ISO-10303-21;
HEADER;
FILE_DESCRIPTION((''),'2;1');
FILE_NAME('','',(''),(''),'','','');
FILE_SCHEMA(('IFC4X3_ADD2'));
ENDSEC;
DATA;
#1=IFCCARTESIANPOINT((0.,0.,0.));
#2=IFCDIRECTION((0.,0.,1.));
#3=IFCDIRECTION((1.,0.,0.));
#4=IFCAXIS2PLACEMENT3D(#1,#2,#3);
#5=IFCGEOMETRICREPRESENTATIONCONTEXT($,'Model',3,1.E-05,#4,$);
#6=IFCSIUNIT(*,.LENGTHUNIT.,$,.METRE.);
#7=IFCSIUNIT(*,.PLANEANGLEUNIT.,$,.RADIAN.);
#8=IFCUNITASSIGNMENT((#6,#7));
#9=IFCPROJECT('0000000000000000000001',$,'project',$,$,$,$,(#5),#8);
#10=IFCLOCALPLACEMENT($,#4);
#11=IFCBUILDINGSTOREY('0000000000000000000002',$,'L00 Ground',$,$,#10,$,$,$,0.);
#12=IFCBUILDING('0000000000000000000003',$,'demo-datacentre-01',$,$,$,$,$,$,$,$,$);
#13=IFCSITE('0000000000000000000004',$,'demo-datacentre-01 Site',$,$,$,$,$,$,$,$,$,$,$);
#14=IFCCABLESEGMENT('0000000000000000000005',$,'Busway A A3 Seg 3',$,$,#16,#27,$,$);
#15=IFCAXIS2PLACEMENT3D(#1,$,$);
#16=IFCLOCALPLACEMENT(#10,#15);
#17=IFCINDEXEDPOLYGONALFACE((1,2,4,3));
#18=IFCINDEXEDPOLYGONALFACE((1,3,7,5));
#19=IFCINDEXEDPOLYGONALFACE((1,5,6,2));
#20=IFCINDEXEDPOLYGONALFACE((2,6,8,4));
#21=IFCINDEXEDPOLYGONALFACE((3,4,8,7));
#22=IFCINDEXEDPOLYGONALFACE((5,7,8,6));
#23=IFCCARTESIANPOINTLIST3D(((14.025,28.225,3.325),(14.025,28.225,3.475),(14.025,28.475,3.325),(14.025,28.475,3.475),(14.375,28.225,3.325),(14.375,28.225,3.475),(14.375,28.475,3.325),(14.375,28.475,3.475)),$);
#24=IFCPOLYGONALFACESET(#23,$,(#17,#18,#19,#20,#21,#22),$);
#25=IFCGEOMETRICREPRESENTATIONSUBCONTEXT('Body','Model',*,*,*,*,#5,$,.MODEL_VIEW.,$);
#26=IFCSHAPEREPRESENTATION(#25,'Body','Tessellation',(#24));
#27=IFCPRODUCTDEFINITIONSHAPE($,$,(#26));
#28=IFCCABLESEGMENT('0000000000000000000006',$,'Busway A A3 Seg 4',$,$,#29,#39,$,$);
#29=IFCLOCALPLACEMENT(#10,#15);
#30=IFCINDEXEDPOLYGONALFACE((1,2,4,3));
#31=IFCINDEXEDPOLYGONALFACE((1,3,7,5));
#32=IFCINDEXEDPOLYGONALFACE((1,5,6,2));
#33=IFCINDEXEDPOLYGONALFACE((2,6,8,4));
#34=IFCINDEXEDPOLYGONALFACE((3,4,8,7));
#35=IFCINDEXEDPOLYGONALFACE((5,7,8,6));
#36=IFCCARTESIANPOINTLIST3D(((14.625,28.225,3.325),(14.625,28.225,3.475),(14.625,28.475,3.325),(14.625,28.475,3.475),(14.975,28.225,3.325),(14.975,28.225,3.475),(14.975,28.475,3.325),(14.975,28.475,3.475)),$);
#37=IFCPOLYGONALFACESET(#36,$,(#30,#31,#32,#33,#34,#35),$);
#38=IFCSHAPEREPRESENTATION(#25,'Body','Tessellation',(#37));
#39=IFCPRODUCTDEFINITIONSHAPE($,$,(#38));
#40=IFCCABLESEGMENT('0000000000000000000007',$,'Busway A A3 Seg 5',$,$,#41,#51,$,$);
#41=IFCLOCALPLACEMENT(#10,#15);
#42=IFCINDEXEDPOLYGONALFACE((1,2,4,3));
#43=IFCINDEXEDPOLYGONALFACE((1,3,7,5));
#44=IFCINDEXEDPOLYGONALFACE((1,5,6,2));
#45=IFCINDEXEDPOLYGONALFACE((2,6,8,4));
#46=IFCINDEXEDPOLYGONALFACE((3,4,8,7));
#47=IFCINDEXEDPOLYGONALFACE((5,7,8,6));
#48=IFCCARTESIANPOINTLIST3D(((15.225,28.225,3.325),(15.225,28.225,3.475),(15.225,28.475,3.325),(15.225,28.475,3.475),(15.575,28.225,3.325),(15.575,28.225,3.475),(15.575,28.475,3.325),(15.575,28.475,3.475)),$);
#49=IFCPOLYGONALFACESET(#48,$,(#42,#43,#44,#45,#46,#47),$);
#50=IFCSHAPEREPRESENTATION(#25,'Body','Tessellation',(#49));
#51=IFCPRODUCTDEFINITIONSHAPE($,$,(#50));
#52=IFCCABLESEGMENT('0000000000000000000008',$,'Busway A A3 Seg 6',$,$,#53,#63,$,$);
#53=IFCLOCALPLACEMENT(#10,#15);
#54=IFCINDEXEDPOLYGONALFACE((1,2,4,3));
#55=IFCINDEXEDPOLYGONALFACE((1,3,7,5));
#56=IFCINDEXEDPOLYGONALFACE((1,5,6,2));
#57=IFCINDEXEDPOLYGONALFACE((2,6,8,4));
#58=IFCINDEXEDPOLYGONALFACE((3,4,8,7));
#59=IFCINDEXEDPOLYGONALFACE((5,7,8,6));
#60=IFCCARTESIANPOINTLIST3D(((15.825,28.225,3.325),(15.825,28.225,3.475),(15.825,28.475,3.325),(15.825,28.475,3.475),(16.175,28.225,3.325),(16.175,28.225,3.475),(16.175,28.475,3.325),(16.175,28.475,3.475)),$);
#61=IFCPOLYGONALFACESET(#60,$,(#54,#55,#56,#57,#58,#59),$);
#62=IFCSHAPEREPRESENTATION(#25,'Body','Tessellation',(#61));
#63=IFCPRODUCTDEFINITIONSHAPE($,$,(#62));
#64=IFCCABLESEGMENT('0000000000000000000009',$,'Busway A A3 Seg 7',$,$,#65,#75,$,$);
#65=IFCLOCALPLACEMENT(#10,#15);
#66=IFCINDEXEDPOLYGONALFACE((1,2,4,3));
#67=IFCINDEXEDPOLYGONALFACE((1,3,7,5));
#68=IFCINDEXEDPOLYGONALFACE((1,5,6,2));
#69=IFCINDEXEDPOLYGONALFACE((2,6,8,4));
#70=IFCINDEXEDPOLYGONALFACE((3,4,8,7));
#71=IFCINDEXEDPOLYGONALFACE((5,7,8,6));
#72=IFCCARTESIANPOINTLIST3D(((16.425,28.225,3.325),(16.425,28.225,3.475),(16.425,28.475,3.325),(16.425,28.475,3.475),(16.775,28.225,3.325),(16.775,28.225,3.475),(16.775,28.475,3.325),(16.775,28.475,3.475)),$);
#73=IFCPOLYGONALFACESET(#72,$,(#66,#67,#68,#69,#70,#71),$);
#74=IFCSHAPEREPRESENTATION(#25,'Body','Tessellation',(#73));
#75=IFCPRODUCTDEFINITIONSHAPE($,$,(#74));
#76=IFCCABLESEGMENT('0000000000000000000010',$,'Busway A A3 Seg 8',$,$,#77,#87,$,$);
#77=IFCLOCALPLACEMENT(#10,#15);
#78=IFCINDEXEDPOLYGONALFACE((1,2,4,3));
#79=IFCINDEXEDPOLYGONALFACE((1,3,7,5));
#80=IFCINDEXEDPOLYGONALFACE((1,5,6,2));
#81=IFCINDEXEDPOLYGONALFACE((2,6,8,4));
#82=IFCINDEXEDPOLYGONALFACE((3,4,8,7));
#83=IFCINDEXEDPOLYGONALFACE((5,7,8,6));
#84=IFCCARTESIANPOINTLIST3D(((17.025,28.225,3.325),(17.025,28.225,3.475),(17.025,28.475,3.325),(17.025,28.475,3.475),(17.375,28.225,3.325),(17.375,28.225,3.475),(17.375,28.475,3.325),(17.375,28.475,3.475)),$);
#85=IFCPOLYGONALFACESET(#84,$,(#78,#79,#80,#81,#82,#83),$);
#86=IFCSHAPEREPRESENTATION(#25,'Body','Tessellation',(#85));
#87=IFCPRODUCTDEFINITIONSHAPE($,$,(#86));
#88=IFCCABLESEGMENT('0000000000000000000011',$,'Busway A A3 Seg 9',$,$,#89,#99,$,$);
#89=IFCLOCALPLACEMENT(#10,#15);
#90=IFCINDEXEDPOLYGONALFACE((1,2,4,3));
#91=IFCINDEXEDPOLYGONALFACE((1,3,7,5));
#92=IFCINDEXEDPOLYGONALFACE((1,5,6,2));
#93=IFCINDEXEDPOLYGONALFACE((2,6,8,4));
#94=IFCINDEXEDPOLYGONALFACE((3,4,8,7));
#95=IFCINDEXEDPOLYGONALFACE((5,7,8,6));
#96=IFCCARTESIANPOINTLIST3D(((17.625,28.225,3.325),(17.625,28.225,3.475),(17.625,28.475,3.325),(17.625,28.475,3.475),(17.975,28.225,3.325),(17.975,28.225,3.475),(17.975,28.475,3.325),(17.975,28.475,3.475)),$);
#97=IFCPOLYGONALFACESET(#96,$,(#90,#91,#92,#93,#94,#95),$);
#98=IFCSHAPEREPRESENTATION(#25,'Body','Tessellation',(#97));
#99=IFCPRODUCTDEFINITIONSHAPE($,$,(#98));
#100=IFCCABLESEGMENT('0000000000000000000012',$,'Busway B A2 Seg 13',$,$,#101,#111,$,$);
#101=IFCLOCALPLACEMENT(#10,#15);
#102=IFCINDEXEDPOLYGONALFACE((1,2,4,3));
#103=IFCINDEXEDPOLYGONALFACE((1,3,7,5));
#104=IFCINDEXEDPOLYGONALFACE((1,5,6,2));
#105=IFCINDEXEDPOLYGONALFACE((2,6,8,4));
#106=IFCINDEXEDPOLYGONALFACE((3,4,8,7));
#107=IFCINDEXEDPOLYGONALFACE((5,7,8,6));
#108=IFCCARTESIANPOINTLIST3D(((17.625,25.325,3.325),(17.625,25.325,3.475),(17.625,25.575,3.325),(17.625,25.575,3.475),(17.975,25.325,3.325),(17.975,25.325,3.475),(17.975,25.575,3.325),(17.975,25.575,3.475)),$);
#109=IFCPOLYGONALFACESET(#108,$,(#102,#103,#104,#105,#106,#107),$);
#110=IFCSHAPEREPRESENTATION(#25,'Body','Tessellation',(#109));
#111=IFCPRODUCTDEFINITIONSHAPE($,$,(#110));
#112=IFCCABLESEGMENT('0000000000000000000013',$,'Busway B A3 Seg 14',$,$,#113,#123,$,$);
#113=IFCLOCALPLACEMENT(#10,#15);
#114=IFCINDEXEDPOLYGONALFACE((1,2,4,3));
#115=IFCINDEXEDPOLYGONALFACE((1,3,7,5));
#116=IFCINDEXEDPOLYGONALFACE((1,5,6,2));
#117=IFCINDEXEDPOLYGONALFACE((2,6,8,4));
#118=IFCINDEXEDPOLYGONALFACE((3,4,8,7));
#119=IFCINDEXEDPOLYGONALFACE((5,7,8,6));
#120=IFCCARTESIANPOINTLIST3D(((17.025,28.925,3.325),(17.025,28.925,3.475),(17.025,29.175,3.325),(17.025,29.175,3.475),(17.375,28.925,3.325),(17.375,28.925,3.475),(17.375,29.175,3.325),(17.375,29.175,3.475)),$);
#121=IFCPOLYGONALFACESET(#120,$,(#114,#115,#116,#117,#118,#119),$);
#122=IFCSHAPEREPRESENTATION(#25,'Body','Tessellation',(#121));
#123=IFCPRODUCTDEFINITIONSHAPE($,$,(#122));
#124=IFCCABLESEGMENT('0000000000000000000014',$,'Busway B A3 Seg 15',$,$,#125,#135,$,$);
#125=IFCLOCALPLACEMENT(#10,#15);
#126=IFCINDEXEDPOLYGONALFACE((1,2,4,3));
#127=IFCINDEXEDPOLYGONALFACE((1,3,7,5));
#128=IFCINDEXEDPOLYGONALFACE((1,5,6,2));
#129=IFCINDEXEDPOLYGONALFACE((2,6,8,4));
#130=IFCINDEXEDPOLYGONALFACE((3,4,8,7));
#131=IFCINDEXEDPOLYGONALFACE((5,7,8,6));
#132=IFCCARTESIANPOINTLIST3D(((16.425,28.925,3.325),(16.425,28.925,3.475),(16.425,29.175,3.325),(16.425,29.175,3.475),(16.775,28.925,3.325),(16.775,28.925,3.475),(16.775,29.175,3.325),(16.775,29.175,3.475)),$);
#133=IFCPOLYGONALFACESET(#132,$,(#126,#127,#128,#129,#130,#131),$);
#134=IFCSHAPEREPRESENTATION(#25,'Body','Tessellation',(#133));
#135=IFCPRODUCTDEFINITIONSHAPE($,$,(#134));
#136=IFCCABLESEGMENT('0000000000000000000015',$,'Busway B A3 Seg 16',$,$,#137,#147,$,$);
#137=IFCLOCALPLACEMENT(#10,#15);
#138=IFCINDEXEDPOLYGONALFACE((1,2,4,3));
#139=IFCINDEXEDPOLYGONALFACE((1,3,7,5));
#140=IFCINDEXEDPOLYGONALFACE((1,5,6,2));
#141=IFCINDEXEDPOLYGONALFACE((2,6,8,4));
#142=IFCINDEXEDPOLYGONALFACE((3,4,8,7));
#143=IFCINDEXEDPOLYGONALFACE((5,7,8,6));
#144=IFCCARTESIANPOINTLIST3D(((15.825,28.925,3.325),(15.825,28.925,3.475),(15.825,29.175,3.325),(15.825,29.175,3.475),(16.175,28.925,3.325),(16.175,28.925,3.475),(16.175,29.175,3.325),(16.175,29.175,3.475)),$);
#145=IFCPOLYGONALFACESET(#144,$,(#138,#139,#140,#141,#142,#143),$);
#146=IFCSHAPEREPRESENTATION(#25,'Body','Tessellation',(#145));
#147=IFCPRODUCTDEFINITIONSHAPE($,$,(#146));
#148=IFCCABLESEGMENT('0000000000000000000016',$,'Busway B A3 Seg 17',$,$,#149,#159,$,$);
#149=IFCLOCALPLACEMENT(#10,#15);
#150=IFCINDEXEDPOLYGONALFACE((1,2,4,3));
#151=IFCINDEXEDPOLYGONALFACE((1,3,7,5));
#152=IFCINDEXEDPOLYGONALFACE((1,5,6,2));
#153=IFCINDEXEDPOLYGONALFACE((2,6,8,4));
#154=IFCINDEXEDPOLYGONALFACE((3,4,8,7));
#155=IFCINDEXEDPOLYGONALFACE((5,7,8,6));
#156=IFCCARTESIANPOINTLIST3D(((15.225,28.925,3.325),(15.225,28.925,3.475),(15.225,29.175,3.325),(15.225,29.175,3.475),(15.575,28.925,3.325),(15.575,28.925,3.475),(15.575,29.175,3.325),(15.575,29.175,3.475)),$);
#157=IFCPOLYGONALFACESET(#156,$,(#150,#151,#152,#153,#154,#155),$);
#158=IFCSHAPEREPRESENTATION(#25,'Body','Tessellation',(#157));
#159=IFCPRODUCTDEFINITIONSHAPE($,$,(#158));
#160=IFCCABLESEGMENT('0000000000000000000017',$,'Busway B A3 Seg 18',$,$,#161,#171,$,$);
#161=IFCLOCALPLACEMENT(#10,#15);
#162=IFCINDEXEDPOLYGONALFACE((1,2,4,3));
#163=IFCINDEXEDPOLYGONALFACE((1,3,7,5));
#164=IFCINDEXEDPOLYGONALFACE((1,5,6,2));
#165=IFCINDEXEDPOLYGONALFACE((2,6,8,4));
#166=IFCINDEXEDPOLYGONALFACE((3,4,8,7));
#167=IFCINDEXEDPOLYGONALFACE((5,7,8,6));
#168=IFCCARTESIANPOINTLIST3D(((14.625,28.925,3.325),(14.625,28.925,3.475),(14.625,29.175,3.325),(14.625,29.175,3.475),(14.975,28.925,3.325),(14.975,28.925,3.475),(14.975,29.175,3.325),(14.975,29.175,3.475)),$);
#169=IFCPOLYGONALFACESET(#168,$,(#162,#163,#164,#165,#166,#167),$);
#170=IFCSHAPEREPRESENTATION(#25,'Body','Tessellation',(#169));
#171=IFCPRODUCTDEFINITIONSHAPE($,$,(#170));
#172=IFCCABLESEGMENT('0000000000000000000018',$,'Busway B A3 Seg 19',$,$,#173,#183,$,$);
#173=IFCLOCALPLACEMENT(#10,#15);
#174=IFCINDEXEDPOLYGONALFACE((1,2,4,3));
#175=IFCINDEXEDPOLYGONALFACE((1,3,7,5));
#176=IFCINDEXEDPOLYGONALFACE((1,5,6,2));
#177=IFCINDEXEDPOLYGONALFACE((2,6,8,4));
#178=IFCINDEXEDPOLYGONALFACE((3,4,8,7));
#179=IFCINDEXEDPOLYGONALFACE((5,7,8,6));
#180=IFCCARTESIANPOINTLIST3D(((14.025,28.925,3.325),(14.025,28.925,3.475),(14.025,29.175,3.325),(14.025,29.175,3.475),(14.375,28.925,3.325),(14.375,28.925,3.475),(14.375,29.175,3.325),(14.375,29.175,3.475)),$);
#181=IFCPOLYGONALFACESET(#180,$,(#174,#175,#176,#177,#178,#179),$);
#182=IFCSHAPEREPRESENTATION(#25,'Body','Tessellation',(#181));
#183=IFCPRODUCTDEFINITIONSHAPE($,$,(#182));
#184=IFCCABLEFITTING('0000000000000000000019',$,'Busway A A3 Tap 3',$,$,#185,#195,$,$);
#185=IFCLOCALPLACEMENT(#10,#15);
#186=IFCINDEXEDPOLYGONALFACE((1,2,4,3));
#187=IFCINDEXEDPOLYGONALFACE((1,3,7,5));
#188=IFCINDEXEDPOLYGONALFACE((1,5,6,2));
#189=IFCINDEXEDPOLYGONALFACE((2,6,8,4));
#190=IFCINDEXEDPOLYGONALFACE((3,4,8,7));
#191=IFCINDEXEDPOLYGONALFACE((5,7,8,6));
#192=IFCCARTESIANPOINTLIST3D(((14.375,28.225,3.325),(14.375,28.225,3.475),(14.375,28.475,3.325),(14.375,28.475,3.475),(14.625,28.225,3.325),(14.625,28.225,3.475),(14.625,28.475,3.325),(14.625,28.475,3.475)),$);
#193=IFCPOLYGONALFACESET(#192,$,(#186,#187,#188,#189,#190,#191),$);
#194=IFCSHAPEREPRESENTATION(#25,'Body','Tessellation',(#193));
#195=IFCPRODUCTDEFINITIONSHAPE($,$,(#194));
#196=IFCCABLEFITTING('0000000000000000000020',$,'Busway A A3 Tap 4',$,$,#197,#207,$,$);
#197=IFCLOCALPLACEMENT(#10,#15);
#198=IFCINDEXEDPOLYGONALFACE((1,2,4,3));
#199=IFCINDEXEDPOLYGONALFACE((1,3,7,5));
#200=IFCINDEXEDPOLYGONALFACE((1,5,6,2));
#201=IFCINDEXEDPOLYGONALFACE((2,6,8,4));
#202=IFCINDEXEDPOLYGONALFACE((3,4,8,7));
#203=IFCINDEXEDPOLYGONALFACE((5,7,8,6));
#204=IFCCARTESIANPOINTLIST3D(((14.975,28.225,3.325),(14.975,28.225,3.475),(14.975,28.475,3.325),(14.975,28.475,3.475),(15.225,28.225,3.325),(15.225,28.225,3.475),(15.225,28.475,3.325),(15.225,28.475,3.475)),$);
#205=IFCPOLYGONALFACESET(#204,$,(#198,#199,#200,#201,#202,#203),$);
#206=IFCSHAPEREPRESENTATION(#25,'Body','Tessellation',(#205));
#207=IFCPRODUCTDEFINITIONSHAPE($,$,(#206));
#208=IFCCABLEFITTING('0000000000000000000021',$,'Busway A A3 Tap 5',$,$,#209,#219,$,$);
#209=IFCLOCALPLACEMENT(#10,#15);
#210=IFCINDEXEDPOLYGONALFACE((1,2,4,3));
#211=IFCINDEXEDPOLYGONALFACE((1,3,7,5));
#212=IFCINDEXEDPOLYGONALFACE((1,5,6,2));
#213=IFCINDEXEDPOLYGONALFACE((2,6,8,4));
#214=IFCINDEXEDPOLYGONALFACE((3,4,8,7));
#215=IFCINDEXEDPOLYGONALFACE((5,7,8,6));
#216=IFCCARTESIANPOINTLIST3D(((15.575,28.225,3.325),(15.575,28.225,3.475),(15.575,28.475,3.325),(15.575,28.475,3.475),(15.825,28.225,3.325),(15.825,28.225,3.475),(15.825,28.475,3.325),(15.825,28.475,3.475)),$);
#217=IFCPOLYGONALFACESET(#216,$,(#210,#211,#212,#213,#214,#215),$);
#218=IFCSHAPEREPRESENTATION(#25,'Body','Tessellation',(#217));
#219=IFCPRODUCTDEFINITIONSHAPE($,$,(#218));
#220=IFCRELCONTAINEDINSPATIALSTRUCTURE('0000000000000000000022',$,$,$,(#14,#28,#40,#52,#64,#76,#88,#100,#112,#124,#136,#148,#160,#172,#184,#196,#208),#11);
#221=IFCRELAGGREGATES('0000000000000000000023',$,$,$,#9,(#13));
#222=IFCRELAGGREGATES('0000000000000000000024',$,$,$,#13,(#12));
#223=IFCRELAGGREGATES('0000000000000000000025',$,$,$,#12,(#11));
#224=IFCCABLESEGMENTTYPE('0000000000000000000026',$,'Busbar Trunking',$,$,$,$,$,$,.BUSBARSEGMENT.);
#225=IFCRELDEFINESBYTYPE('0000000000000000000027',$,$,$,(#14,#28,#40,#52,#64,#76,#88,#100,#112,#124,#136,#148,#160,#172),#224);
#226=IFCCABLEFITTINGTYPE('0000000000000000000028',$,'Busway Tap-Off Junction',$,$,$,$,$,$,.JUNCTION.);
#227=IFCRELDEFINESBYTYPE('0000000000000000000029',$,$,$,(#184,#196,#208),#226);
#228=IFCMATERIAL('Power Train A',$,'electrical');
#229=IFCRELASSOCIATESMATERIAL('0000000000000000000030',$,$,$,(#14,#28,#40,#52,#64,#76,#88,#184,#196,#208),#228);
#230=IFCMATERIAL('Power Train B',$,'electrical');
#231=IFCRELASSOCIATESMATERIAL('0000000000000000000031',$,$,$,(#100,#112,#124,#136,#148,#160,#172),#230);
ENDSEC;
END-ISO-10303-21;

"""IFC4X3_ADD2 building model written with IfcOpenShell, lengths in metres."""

from ifc_helpers import new_model, si_unit, frame, origin_with_axes, place, context, subcontext, project, spatial, rectangle, extrude, material, type_object, element, save


model = new_model("IFC4X3_ADD2")

# Units and contexts
model_context = context("Model", 3, precision=1e-05, world=origin_with_axes())
body_context = subcontext(model_context, "Body", "Model", "MODEL_VIEW")
ifc_project = project(units=[si_unit("LENGTHUNIT", "METRE"), si_unit("PLANEANGLEUNIT", "RADIAN")], contexts=[model_context])

# Site, building, storey
site = spatial("IfcSite", under=ifc_project, Name="demo-datacentre-01 Site")
building = spatial("IfcBuilding", under=site, Name="demo-datacentre-01")
storey_placement = place(None, origin_with_axes())
storey = spatial("IfcBuildingStorey", under=building, at=storey_placement, Name="L00 Ground", Elevation=0.0)

# Cable segments
ifc_material_1 = material(Name="Power Train A", Category="electrical")
cable_segment_type_1 = type_object("IfcCableSegmentType", Name="Busbar Trunking", PredefinedType="BUSBARSEGMENT")
cable_segment_1_placement = place(storey_placement, frame((14.025, 28.35, 3.4), z_axis=(1.0, 0.0, 0.0), x_axis=(0.0, 1.0, 0.0)))
element("IfcCableSegment", 1, at=cable_segment_1_placement, inside=storey, type_object=cable_segment_type_1, material=ifc_material_1, Name="Busway A A3 Seg 3", context=body_context, shape_type="SweptSolid", body=[
    extrude(rectangle(XDim=0.25, YDim=0.15), origin_with_axes(), (0.0, 0.0, 1.0), 0.35),
])
cable_segment_2_placement = place(storey_placement, frame((14.625, 28.35, 3.4), z_axis=(1.0, 0.0, 0.0), x_axis=(0.0, 1.0, 0.0)))
element("IfcCableSegment", 2, at=cable_segment_2_placement, inside=storey, type_object=cable_segment_type_1, material=ifc_material_1, Name="Busway A A3 Seg 4", context=body_context, shape_type="SweptSolid", body=[
    extrude(rectangle(XDim=0.25, YDim=0.15), origin_with_axes(), (0.0, 0.0, 1.0), 0.35),
])
for number, where, z_axis, x_axis, name in (
    (3, (15.225, 28.35, 3.4), (1.0, 0.0, 0.0), (0.0, 1.0, 0.0), "Busway A A3 Seg 5"),
    (4, (15.825, 28.35, 3.4), (1.0, 0.0, 0.0), (0.0, 1.0, 0.0), "Busway A A3 Seg 6"),
):
    element("IfcCableSegment", number, at=place(storey_placement, frame(where, z_axis=z_axis, x_axis=x_axis)), inside=storey, type_object=cable_segment_type_1, material=ifc_material_1, Name=name, context=body_context, shape_type="SweptSolid", body=[
        extrude(rectangle(XDim=0.25, YDim=0.15), origin_with_axes(), (0.0, 0.0, 1.0), 0.35),
    ])
cable_segment_3_placement = place(storey_placement, frame((16.425, 28.35, 3.4), z_axis=(1.0, 0.0, 0.0), x_axis=(0.0, 1.0, 0.0)))
element("IfcCableSegment", 5, at=cable_segment_3_placement, inside=storey, type_object=cable_segment_type_1, material=ifc_material_1, Name="Busway A A3 Seg 7", context=body_context, shape_type="SweptSolid", body=[
    extrude(rectangle(XDim=0.25, YDim=0.15), origin_with_axes(), (0.0, 0.0, 1.0), 0.35),
])
for number, where, z_axis, x_axis, name in (
    (6, (17.025, 28.35, 3.4), (1.0, 0.0, 0.0), (0.0, 1.0, 0.0), "Busway A A3 Seg 8"),
    (7, (17.625, 28.35, 3.4), (1.0, 0.0, 0.0), (0.0, 1.0, 0.0), "Busway A A3 Seg 9"),
):
    element("IfcCableSegment", number, at=place(storey_placement, frame(where, z_axis=z_axis, x_axis=x_axis)), inside=storey, type_object=cable_segment_type_1, material=ifc_material_1, Name=name, context=body_context, shape_type="SweptSolid", body=[
        extrude(rectangle(XDim=0.25, YDim=0.15), origin_with_axes(), (0.0, 0.0, 1.0), 0.35),
    ])
ifc_material_2 = material(Name="Power Train B", Category="electrical")
for number, where, z_axis, x_axis, name in (
    (8, (17.975, 25.45, 3.4), (-1.0, 0.0, 0.0), (0.0, -1.0, 0.0), "Busway B A2 Seg 13"),
    (9, (17.375, 29.05, 3.4), (-1.0, 0.0, 0.0), (0.0, -1.0, 0.0), "Busway B A3 Seg 14"),
):
    element("IfcCableSegment", number, at=place(storey_placement, frame(where, z_axis=z_axis, x_axis=x_axis)), inside=storey, type_object=cable_segment_type_1, material=ifc_material_2, Name=name, context=body_context, shape_type="SweptSolid", body=[
        extrude(rectangle(XDim=0.25, YDim=0.15), origin_with_axes(), (0.0, 0.0, 1.0), 0.35),
    ])
cable_segment_4_placement = place(storey_placement, frame((16.775, 29.05, 3.4), z_axis=(-1.0, 0.0, 0.0), x_axis=(0.0, -1.0, 0.0)))
element("IfcCableSegment", 10, at=cable_segment_4_placement, inside=storey, type_object=cable_segment_type_1, material=ifc_material_2, Name="Busway B A3 Seg 15", context=body_context, shape_type="SweptSolid", body=[
    extrude(rectangle(XDim=0.25, YDim=0.15), origin_with_axes(), (0.0, 0.0, 1.0), 0.35),
])
for number, where, z_axis, x_axis, name in (
    (11, (16.175, 29.05, 3.4), (-1.0, 0.0, 0.0), (0.0, -1.0, 0.0), "Busway B A3 Seg 16"),
    (12, (15.575, 29.05, 3.4), (-1.0, 0.0, 0.0), (0.0, -1.0, 0.0), "Busway B A3 Seg 17"),
):
    element("IfcCableSegment", number, at=place(storey_placement, frame(where, z_axis=z_axis, x_axis=x_axis)), inside=storey, type_object=cable_segment_type_1, material=ifc_material_2, Name=name, context=body_context, shape_type="SweptSolid", body=[
        extrude(rectangle(XDim=0.25, YDim=0.15), origin_with_axes(), (0.0, 0.0, 1.0), 0.35),
    ])
cable_segment_5_placement = place(storey_placement, frame((14.975, 29.05, 3.4), z_axis=(-1.0, 0.0, 0.0), x_axis=(0.0, -1.0, 0.0)))
element("IfcCableSegment", 13, at=cable_segment_5_placement, inside=storey, type_object=cable_segment_type_1, material=ifc_material_2, Name="Busway B A3 Seg 18", context=body_context, shape_type="SweptSolid", body=[
    extrude(rectangle(XDim=0.25, YDim=0.15), origin_with_axes(), (0.0, 0.0, 1.0), 0.35),
])
cable_segment_6_placement = place(storey_placement, frame((14.375, 29.05, 3.4), z_axis=(-1.0, 0.0, 0.0), x_axis=(0.0, -1.0, 0.0)))
element("IfcCableSegment", 14, at=cable_segment_6_placement, inside=storey, type_object=cable_segment_type_1, material=ifc_material_2, Name="Busway B A3 Seg 19", context=body_context, shape_type="SweptSolid", body=[
    extrude(rectangle(XDim=0.25, YDim=0.15), origin_with_axes(), (0.0, 0.0, 1.0), 0.35),
])

# Cable fittings
cable_fitting_type = type_object("IfcCableFittingType", Name="Busway Tap-Off Junction", PredefinedType="JUNCTION")
for number, where, z_axis, x_axis, name in (
    (15, (14.5, 28.35, 3.325), (0.0, 0.0, 1.0), (1.0, 0.0, 0.0), "Busway A A3 Tap 3"),
    (16, (15.1, 28.35, 3.325), (0.0, 0.0, 1.0), (1.0, 0.0, 0.0), "Busway A A3 Tap 4"),
    (17, (15.7, 28.35, 3.325), (0.0, 0.0, 1.0), (1.0, 0.0, 0.0), "Busway A A3 Tap 5"),
):
    element("IfcCableFitting", number, at=place(storey_placement, frame(where, z_axis=z_axis, x_axis=x_axis)), inside=storey, type_object=cable_fitting_type, material=ifc_material_1, Name=name, context=body_context, shape_type="SweptSolid", body=[
        extrude(rectangle(XDim=0.25, YDim=0.25), origin_with_axes(), (0.0, 0.0, 1.0), 0.15),
    ])

save(model, "model.ifc")
